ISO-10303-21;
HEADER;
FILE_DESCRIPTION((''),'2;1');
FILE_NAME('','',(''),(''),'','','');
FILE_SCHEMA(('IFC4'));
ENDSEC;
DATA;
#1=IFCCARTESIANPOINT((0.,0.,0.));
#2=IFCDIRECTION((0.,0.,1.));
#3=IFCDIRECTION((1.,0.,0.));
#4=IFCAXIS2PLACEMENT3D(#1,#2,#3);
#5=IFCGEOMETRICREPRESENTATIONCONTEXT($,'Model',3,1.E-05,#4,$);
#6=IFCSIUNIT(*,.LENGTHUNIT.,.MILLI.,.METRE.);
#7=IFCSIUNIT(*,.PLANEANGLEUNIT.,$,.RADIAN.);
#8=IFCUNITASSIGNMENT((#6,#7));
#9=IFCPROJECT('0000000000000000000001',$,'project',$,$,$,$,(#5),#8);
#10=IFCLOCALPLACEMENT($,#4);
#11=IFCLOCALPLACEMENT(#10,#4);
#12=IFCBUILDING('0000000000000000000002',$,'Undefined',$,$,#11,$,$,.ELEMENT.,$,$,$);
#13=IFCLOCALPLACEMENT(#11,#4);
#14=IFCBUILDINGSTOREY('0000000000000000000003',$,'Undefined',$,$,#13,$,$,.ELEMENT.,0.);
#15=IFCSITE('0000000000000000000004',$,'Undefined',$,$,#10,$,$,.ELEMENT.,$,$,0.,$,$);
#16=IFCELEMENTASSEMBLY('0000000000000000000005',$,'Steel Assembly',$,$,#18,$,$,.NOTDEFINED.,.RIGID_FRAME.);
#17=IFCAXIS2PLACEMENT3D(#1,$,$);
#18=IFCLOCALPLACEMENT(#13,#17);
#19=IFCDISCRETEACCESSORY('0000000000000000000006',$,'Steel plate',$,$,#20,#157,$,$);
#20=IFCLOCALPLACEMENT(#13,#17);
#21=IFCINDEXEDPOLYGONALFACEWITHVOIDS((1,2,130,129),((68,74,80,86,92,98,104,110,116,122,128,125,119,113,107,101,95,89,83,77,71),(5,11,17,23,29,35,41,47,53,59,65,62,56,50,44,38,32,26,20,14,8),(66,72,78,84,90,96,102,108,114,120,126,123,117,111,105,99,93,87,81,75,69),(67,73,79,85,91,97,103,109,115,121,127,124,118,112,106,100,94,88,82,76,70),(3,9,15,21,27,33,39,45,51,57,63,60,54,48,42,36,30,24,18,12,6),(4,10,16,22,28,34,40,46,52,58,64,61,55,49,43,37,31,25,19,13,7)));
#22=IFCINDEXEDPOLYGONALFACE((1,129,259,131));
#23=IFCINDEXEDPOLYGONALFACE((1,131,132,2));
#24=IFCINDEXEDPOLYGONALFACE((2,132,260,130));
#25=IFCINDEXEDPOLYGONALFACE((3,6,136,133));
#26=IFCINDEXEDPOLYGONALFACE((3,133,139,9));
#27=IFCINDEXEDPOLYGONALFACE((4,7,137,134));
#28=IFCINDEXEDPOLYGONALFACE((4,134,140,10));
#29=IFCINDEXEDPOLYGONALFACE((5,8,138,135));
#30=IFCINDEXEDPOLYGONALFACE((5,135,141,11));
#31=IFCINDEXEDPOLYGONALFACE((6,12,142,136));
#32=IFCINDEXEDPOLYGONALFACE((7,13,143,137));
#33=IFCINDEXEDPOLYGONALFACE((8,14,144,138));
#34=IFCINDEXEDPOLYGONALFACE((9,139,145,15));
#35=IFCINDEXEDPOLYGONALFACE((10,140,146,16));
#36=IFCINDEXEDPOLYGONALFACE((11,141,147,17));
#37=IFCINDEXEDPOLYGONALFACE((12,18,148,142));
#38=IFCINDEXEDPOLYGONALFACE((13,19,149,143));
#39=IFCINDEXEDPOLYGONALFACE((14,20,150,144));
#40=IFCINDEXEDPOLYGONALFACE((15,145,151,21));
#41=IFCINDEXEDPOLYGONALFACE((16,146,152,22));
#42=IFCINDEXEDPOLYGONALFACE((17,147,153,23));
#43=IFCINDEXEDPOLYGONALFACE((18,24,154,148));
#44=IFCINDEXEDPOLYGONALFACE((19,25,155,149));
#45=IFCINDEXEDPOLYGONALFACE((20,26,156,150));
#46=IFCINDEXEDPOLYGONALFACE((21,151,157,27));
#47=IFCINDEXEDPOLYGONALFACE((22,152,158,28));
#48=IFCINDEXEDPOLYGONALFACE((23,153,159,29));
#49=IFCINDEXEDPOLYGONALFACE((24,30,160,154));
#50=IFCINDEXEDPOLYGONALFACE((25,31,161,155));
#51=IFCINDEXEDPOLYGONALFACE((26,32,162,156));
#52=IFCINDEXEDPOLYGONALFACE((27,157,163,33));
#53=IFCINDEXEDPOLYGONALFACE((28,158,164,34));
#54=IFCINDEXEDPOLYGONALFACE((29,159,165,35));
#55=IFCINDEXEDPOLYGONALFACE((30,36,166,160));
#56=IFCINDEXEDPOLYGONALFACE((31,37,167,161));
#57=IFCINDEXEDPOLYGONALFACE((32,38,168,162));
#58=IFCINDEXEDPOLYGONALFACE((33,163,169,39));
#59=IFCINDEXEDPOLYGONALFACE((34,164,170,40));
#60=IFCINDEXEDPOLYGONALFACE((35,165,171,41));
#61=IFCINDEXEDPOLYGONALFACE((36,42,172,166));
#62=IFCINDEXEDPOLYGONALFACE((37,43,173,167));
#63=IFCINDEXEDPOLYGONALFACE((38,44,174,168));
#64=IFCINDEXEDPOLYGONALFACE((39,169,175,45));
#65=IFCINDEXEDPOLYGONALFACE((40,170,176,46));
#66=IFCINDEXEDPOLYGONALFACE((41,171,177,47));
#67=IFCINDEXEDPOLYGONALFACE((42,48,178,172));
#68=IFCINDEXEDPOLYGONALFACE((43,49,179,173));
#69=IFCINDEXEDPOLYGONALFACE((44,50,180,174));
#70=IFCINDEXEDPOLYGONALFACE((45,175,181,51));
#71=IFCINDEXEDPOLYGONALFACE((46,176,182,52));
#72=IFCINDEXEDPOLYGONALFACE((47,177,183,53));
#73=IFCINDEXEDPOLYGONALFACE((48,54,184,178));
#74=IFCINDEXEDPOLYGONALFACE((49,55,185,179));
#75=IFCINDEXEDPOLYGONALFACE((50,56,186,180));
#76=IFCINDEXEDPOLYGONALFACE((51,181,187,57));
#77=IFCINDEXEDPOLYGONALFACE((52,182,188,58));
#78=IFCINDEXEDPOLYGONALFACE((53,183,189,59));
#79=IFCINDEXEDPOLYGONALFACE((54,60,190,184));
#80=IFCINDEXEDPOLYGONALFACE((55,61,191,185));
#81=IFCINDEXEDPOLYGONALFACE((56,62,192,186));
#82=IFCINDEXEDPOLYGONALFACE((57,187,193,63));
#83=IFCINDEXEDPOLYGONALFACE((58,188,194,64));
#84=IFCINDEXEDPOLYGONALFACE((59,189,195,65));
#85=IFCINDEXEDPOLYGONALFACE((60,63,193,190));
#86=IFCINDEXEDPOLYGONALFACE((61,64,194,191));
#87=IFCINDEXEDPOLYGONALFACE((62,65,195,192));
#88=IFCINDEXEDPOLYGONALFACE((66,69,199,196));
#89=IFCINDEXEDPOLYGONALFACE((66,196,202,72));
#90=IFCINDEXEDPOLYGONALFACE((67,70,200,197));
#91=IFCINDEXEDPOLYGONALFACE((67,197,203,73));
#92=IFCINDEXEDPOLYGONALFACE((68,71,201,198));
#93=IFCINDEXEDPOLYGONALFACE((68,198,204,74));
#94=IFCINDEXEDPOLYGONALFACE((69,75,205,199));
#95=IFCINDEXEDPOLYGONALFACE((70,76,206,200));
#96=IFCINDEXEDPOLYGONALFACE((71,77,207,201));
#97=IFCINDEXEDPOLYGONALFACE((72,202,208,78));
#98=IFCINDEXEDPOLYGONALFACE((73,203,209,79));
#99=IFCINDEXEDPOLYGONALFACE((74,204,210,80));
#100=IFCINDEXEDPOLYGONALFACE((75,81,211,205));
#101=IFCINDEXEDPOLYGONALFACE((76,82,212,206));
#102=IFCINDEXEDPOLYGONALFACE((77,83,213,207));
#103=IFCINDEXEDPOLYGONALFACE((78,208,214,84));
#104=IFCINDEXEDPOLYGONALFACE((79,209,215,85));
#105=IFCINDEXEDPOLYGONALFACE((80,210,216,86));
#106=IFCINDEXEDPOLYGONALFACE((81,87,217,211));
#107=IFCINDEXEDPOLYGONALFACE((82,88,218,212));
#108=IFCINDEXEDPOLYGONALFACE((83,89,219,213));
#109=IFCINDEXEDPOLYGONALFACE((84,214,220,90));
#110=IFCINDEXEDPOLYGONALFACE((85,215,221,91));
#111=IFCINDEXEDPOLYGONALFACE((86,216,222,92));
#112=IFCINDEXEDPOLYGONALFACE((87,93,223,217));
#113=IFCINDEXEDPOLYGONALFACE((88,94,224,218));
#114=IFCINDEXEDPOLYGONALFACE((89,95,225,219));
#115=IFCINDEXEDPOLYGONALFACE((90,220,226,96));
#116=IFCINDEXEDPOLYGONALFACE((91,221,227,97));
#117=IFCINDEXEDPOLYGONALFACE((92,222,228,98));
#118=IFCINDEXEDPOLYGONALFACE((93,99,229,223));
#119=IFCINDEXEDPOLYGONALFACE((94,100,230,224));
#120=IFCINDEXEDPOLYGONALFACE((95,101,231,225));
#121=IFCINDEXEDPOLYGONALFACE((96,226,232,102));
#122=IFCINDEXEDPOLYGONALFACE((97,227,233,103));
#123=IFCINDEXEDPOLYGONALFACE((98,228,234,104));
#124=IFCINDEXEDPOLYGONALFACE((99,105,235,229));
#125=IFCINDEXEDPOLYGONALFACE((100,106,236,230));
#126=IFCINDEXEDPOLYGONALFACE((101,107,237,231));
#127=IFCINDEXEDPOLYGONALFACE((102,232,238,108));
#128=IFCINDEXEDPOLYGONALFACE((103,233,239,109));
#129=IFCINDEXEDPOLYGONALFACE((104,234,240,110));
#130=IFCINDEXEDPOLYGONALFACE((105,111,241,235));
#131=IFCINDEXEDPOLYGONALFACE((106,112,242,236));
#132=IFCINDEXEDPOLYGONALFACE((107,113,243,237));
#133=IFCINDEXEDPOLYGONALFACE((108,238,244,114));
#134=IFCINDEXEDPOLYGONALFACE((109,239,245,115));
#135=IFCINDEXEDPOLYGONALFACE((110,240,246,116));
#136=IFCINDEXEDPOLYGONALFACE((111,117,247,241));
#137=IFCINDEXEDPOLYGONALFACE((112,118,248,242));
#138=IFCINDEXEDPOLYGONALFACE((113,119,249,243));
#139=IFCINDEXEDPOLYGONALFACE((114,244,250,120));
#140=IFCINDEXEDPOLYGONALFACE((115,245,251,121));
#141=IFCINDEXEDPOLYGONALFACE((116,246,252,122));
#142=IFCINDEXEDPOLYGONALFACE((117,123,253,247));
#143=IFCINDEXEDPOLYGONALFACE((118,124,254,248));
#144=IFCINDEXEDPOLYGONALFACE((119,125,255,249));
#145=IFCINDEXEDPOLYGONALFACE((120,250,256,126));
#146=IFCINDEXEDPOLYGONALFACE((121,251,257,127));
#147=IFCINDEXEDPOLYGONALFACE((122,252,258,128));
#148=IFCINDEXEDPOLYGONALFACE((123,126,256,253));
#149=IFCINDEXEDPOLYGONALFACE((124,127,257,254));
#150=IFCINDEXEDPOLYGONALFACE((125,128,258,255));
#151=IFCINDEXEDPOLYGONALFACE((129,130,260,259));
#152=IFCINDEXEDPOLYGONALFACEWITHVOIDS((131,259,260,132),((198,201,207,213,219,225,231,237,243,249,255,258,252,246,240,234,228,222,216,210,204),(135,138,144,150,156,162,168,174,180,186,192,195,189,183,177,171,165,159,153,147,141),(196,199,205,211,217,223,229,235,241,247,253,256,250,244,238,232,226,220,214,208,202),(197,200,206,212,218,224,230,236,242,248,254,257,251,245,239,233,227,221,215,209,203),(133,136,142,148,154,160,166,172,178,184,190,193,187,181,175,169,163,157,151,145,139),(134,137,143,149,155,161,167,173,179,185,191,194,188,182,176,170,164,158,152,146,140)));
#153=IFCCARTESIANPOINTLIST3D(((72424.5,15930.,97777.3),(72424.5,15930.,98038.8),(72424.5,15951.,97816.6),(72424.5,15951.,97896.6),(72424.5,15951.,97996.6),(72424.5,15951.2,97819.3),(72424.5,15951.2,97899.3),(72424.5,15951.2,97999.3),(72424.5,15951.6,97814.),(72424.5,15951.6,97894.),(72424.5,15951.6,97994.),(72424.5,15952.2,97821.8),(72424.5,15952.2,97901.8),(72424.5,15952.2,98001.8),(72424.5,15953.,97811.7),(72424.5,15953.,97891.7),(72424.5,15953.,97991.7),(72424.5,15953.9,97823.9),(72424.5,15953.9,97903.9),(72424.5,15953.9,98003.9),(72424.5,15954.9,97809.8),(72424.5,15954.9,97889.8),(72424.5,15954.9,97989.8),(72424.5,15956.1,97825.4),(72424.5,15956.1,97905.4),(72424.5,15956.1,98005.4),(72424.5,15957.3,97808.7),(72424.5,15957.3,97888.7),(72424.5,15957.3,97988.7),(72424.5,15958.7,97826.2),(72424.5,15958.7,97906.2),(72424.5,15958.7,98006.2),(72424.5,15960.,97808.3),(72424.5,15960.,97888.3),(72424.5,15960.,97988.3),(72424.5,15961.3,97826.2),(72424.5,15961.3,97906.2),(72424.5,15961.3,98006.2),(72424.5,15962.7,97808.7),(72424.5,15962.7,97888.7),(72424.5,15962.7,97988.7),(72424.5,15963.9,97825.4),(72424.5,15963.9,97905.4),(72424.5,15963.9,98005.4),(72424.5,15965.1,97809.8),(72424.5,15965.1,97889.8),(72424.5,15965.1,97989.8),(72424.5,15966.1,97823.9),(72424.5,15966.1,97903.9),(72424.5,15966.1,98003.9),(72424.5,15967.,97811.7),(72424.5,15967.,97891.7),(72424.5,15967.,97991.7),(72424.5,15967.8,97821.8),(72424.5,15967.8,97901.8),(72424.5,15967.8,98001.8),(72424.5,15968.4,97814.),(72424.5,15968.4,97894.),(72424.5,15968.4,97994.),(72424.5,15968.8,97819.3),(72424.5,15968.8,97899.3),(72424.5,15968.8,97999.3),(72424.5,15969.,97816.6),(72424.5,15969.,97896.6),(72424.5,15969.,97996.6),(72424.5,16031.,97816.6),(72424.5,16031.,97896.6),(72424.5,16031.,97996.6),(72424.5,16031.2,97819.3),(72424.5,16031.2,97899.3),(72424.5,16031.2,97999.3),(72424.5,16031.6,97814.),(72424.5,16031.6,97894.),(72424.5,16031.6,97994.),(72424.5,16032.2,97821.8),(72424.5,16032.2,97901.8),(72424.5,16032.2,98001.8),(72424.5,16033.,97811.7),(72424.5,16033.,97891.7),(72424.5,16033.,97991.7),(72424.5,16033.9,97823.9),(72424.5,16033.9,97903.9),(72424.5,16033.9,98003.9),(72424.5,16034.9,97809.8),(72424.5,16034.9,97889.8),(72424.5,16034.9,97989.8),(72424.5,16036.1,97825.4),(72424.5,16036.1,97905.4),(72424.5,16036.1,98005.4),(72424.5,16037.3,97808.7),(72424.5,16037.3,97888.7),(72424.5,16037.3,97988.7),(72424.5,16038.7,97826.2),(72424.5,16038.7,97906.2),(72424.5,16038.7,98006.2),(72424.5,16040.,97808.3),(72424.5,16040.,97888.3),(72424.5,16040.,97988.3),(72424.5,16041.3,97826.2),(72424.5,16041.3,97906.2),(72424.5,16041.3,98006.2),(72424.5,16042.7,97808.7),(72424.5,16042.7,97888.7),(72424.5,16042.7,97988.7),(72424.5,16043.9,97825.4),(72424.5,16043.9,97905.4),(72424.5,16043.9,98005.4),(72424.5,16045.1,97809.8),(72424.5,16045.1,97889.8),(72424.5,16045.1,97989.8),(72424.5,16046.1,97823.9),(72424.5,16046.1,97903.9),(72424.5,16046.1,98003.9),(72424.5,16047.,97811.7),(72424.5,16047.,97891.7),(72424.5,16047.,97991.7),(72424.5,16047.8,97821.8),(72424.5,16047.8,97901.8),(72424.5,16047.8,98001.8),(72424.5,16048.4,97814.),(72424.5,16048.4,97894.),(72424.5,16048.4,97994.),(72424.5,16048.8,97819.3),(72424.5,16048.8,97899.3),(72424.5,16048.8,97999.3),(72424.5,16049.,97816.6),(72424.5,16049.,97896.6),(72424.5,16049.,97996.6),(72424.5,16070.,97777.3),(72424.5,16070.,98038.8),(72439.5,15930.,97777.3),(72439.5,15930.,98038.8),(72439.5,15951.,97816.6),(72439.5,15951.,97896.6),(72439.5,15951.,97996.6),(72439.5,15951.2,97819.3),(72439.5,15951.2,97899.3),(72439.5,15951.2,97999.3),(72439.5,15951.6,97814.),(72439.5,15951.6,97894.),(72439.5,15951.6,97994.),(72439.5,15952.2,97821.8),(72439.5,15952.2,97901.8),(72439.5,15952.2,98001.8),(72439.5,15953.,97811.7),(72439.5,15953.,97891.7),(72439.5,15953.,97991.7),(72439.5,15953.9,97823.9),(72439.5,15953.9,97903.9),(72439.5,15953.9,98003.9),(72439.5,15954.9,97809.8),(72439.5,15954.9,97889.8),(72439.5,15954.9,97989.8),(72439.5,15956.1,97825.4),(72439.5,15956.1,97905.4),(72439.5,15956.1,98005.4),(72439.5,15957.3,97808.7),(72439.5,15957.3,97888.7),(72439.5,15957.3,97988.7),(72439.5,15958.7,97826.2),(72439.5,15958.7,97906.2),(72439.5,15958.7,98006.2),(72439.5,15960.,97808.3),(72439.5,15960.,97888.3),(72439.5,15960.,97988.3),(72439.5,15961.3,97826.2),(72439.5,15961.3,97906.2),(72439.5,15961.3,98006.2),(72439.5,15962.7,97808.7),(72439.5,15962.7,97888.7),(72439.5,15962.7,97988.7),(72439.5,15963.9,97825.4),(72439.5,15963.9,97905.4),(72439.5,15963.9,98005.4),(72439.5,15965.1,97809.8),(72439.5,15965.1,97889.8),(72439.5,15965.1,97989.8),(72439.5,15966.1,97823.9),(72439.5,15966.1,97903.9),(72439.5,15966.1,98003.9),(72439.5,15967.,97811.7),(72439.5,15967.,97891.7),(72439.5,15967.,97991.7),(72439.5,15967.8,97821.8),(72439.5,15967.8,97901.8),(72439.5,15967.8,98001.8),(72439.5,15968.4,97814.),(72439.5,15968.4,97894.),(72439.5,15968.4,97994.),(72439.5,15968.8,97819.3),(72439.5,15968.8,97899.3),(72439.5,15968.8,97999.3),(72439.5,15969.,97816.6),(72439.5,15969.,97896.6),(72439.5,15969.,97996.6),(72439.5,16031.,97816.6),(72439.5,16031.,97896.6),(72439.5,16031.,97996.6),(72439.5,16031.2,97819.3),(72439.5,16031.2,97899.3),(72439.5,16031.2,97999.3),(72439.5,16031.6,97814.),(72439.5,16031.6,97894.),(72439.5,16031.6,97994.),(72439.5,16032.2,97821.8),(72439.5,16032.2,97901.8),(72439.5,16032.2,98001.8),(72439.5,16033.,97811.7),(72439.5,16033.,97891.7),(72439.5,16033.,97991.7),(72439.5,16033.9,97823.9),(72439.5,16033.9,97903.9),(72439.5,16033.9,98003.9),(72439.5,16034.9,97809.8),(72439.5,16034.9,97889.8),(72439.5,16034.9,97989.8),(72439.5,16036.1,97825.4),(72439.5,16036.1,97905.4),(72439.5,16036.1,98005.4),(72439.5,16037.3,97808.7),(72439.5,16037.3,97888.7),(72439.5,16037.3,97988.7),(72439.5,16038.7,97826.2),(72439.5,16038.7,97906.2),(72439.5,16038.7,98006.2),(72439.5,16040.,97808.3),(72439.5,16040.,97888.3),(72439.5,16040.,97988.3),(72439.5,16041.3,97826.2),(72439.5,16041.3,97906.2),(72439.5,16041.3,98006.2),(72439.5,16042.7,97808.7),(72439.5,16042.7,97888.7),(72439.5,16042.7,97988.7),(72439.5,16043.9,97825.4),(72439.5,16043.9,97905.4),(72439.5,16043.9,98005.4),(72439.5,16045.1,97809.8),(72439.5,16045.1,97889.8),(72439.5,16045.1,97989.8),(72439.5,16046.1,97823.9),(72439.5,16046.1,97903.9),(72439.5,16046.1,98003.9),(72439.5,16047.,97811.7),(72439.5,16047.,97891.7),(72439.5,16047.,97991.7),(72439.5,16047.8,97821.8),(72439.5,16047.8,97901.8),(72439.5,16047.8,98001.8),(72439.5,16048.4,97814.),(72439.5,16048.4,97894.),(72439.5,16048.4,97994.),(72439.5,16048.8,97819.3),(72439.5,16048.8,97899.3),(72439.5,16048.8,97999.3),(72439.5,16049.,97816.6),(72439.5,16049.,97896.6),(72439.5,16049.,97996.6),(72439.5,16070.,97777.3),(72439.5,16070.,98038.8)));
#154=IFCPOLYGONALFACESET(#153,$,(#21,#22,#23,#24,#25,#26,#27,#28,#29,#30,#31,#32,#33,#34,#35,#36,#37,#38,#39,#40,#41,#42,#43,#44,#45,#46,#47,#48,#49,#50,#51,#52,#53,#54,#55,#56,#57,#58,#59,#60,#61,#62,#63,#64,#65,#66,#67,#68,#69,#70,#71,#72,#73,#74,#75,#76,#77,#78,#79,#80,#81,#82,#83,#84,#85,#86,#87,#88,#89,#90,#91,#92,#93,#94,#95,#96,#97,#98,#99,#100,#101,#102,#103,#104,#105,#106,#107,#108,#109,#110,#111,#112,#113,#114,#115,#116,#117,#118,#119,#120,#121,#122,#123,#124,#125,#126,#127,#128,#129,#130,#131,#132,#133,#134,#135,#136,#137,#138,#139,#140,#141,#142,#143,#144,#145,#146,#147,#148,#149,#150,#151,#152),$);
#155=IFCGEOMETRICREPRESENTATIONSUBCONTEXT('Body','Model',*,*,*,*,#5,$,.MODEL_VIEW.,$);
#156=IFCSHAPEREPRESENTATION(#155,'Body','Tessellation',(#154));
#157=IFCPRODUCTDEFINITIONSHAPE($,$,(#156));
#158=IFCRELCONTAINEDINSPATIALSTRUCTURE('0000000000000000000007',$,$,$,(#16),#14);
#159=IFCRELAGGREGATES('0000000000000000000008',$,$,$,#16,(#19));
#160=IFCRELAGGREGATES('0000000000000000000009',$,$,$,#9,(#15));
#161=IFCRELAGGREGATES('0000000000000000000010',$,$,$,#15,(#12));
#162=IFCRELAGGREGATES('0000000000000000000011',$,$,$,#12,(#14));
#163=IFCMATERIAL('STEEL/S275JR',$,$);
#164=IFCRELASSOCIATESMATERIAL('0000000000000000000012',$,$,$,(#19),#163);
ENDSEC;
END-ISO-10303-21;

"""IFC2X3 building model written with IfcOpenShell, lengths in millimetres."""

from ifc_helpers import new_model, si_unit, frame, origin_with_axes, origin_2d_with_axis, place, context, subcontext, project, spatial, polyline, circle, outline, extrude, source, transform, mapped, material, element, aggregate, save


model = new_model("IFC2X3")

# Units and contexts
model_context = context("Model", 3, precision=1e-05, world=origin_with_axes())
body_context = subcontext(model_context, "Body", "Model", "MODEL_VIEW")
ifc_project = project(units=[si_unit("LENGTHUNIT", "METRE", prefix="MILLI"), si_unit("PLANEANGLEUNIT", "RADIAN")], contexts=[model_context])

# Site, building, storey
site_placement = place(None, origin_with_axes())
site = spatial("IfcSite", under=ifc_project, at=site_placement, Name="Undefined", CompositionType="ELEMENT", RefElevation=0.0)
building_placement = place(site_placement, origin_with_axes())
building = spatial("IfcBuilding", under=site, at=building_placement, Name="Undefined", CompositionType="ELEMENT")
storey_placement = place(building_placement, origin_with_axes())
storey = spatial("IfcBuildingStorey", under=building, at=storey_placement, Name="Undefined", CompositionType="ELEMENT", Elevation=0.0)

# Shared definitions
ifc_material_1 = material(Name="STEEL/S275JR")

# Element assembly
assembly_1_placement = place(storey_placement, origin_with_axes())
assembly_1 = element("IfcElementAssembly", 1, at=assembly_1_placement, inside=storey, Name="Steel Assembly", AssemblyPlace="NOTDEFINED", PredefinedType="RIGID_FRAME")

# Discrete accessory, opening
discrete_accessory_1_placement = place(assembly_1_placement, frame((72432.0, 15930.0, 98038.8), z_axis=(-1.0, 0.0, 0.0), x_axis=(0.0, 1.0, 0.0)))
discrete_accessory_1 = element("IfcDiscreteAccessory", 2, at=discrete_accessory_1_placement, material=ifc_material_1, Name="Steel plate", context=body_context, shape_type="SweptSolid", body=[
    extrude(outline(polyline([(0.0, 0.0), (140.0, 0.0), (140.0, 261.5), (0.0, 261.5), (0.0, 0.0)])), frame((0.0, 0.0, -7.5), z_axis=(0.0, 0.0, 1.0), x_axis=(1.0, 0.0, 0.0)), (0.0, 0.0, 1.0), 15.0),
])
shared_shape_1 = source(origin_with_axes(), body_context, "Body", "SweptSolid", [
    extrude(circle(Radius=9.0, at=origin_2d_with_axis()), frame((0.0, -15.1, 0.0), z_axis=(0.0, 1.0, 0.0), x_axis=(1.0, 0.0, 0.0)), (0.0, 0.0, 1.0), 30.3),
])
opening_1_placement = place(assembly_1_placement, frame((72439.5, 16000.0, 97997.3), z_axis=(0.0, -1.0, 0.0), x_axis=(0.0, 0.0, -1.0)))
element("IfcOpeningElement", 3, at=opening_1_placement, cuts=discrete_accessory_1, ObjectType="Opening", context=body_context, shape_type="MappedRepresentation", body=[
    mapped(shared_shape_1, transform((0.0, 0.0, -40.0))),
    mapped(shared_shape_1, transform((100.0, 0.0, -40.0))),
    mapped(shared_shape_1, transform((180.0, 0.0, -40.0))),
    mapped(shared_shape_1, transform((0.0, 0.0, 40.0))),
    mapped(shared_shape_1, transform((100.0, 0.0, 40.0))),
    mapped(shared_shape_1, transform((180.0, 0.0, 40.0))),
])
aggregate(assembly_1, [discrete_accessory_1])

save(model, "model.ifc")
